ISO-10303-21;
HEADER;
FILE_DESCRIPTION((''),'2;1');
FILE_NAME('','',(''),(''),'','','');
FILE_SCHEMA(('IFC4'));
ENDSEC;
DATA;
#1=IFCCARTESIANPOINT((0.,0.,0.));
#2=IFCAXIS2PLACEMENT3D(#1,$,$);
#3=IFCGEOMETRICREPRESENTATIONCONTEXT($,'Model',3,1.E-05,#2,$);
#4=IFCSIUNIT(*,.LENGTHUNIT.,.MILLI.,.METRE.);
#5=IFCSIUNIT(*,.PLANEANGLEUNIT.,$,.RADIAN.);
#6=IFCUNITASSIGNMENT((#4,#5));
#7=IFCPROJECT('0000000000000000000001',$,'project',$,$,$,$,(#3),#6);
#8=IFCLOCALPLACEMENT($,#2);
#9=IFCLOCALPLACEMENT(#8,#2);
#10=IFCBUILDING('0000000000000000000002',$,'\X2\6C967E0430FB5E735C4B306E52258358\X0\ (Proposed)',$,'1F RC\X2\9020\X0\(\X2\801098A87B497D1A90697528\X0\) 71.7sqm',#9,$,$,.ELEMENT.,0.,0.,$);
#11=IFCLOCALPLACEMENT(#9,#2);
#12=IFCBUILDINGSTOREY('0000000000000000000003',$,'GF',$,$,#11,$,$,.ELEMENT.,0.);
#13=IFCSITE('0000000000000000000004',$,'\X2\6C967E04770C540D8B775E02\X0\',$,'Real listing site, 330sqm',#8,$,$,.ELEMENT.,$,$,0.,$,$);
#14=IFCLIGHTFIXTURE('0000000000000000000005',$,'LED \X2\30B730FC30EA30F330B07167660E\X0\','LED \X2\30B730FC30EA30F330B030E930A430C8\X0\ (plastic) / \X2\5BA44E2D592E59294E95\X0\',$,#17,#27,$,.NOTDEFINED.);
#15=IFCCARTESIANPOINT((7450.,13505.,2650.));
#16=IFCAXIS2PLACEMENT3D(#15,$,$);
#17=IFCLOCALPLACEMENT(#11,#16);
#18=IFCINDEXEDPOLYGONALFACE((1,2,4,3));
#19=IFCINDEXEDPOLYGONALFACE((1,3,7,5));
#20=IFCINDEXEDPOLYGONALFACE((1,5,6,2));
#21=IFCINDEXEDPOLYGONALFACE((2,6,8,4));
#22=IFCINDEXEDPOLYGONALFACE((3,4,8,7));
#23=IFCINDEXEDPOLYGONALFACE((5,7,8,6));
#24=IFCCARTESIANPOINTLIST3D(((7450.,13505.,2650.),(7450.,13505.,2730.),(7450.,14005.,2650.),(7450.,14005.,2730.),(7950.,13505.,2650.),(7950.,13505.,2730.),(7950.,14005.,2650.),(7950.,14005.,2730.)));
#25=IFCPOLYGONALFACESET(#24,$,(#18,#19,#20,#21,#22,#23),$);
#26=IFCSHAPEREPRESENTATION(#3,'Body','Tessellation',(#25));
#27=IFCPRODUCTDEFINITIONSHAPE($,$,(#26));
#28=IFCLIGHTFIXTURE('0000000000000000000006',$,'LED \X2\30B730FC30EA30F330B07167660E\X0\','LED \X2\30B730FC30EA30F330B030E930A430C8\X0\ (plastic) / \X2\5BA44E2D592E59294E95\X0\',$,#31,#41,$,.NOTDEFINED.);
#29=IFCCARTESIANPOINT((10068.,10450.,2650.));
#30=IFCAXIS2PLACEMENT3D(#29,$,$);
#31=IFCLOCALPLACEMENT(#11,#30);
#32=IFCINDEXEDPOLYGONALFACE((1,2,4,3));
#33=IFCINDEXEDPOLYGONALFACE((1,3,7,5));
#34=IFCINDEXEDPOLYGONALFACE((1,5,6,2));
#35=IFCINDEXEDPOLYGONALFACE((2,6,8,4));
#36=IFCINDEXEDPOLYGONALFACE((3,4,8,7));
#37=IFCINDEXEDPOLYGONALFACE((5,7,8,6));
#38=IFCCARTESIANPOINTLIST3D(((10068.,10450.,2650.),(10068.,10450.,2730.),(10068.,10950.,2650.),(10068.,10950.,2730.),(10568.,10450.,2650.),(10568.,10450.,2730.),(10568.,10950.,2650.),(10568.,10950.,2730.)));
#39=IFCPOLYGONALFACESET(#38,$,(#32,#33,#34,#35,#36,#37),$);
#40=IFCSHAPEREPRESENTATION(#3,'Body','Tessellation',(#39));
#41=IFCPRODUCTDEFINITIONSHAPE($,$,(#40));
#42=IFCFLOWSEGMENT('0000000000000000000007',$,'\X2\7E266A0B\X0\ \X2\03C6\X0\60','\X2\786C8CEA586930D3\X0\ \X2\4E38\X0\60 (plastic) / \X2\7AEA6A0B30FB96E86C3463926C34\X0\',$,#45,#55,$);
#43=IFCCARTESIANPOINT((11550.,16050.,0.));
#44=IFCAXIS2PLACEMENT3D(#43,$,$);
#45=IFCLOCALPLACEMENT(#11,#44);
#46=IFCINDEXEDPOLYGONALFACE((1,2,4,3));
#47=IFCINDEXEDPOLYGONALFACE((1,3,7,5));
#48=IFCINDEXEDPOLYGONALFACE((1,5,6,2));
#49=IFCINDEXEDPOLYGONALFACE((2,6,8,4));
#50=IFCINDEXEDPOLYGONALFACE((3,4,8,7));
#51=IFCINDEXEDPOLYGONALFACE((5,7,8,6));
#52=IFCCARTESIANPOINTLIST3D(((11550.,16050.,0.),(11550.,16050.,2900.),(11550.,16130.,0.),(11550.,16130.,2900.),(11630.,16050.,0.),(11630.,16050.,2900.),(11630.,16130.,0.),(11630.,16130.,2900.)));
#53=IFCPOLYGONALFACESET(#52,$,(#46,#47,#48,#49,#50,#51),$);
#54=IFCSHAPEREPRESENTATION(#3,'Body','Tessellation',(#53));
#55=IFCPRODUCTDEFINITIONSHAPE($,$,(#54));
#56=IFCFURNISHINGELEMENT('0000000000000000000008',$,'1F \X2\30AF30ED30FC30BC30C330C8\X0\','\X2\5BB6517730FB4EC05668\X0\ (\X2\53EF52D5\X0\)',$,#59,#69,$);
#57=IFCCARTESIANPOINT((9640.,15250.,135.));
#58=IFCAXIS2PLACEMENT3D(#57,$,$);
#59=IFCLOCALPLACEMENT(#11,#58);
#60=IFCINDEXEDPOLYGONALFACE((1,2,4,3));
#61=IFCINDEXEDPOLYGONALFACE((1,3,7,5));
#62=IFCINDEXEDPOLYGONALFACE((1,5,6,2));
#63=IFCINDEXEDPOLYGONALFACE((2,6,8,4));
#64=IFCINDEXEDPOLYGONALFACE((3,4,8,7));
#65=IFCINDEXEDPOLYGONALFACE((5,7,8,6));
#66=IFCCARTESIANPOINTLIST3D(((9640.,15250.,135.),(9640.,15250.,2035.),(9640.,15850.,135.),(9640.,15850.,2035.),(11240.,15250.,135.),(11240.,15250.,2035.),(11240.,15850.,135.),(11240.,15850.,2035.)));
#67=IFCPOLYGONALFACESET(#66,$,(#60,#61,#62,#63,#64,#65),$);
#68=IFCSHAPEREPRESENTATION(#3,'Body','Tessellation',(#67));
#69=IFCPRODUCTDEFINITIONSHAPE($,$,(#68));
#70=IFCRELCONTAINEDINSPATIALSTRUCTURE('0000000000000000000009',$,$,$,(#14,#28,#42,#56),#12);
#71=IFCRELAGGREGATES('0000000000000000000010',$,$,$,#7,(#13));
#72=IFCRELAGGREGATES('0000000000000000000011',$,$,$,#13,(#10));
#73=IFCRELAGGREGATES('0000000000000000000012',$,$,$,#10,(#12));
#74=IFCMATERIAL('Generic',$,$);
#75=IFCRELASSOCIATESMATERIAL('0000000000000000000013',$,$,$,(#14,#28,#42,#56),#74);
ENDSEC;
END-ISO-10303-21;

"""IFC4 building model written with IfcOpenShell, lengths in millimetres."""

from ifc_helpers import new_model, si_unit, frame, frame_2d, origin, place, context, project, spatial, rectangle, extrude, material, element, save


model = new_model("IFC4")

# Units and contexts
model_context = context("Model", 3, precision=1e-05, world=origin())
ifc_project = project(units=[si_unit("LENGTHUNIT", "METRE", prefix="MILLI"), si_unit("PLANEANGLEUNIT", "RADIAN")], contexts=[model_context])

# Site, building, storey
site_placement = place(None, origin())
site = spatial("IfcSite", under=ifc_project, at=site_placement, Name="沖縄県名護市", ObjectType="Real listing site, 330sqm", CompositionType="ELEMENT", RefElevation=0.0)
building_placement = place(site_placement, origin())
building = spatial("IfcBuilding", under=site, at=building_placement, Name="沖縄・平屋の別荘 (Proposed)", ObjectType="1F RC造(耐風等級適用) 71.7sqm", CompositionType="ELEMENT", ElevationOfRefHeight=0.0, ElevationOfTerrain=0.0)
storey_placement = place(building_placement, origin())
storey = spatial("IfcBuildingStorey", under=building, at=storey_placement, Name="GF", CompositionType="ELEMENT", Elevation=0.0)

# Shared definitions
ifc_material_1 = material(Name="Generic")

# Light fixtures
light_fixture_1_placement = place(storey_placement, frame((7450.0, 13505.0, 2650.0)))
element("IfcLightFixture", 1, at=light_fixture_1_placement, inside=storey, material=ifc_material_1, Name="LED シーリング照明", Description="LED シーリングライト (plastic) / 室中央天井", PredefinedType="NOTDEFINED", context=model_context, shape_type="SweptSolid", body=[
    extrude(rectangle(XDim=500.0, YDim=500.0, at=frame_2d((250.0, 250.0))), frame((7450.0, 13505.0, 2650.0)), (0.0, 0.0, 1.0), 80.0),
])
light_fixture_2_placement = place(storey_placement, frame((10068.0, 10450.0, 2650.0)))
element("IfcLightFixture", 2, at=light_fixture_2_placement, inside=storey, material=ifc_material_1, Name="LED シーリング照明", Description="LED シーリングライト (plastic) / 室中央天井", PredefinedType="NOTDEFINED", context=model_context, shape_type="SweptSolid", body=[
    extrude(rectangle(XDim=500.0, YDim=500.0, at=frame_2d((250.0, 250.0))), frame((10068.0, 10450.0, 2650.0)), (0.0, 0.0, 1.0), 80.0),
])

# Flow segment
flow_segment_placement = place(storey_placement, frame((11550.0, 16050.0, 0.0)))
element("IfcFlowSegment", 3, at=flow_segment_placement, inside=storey, material=ifc_material_1, Name="縦樋 φ60", Description="硬質塩ビ 丸60 (plastic) / 竪樋・雨水排水", context=model_context, shape_type="SweptSolid", body=[
    extrude(rectangle(XDim=80.0, YDim=80.0, at=frame_2d((40.0, 40.0))), frame((11550.0, 16050.0, 0.0)), (0.0, 0.0, 1.0), 2900.0),
])

# Furnishing element
furnishing_placement = place(storey_placement, frame((9640.0, 15250.0, 135.0)))
element("IfcFurnishingElement", 4, at=furnishing_placement, inside=storey, material=ifc_material_1, Name="1F クローゼット", Description="家具・什器 (可動)", context=model_context, shape_type="SweptSolid", body=[
    extrude(rectangle(XDim=1600.0, YDim=600.0, at=frame_2d((800.0, 300.0))), frame((9640.0, 15250.0, 135.0)), (0.0, 0.0, 1.0), 1900.0),
])

save(model, "model.ifc")
